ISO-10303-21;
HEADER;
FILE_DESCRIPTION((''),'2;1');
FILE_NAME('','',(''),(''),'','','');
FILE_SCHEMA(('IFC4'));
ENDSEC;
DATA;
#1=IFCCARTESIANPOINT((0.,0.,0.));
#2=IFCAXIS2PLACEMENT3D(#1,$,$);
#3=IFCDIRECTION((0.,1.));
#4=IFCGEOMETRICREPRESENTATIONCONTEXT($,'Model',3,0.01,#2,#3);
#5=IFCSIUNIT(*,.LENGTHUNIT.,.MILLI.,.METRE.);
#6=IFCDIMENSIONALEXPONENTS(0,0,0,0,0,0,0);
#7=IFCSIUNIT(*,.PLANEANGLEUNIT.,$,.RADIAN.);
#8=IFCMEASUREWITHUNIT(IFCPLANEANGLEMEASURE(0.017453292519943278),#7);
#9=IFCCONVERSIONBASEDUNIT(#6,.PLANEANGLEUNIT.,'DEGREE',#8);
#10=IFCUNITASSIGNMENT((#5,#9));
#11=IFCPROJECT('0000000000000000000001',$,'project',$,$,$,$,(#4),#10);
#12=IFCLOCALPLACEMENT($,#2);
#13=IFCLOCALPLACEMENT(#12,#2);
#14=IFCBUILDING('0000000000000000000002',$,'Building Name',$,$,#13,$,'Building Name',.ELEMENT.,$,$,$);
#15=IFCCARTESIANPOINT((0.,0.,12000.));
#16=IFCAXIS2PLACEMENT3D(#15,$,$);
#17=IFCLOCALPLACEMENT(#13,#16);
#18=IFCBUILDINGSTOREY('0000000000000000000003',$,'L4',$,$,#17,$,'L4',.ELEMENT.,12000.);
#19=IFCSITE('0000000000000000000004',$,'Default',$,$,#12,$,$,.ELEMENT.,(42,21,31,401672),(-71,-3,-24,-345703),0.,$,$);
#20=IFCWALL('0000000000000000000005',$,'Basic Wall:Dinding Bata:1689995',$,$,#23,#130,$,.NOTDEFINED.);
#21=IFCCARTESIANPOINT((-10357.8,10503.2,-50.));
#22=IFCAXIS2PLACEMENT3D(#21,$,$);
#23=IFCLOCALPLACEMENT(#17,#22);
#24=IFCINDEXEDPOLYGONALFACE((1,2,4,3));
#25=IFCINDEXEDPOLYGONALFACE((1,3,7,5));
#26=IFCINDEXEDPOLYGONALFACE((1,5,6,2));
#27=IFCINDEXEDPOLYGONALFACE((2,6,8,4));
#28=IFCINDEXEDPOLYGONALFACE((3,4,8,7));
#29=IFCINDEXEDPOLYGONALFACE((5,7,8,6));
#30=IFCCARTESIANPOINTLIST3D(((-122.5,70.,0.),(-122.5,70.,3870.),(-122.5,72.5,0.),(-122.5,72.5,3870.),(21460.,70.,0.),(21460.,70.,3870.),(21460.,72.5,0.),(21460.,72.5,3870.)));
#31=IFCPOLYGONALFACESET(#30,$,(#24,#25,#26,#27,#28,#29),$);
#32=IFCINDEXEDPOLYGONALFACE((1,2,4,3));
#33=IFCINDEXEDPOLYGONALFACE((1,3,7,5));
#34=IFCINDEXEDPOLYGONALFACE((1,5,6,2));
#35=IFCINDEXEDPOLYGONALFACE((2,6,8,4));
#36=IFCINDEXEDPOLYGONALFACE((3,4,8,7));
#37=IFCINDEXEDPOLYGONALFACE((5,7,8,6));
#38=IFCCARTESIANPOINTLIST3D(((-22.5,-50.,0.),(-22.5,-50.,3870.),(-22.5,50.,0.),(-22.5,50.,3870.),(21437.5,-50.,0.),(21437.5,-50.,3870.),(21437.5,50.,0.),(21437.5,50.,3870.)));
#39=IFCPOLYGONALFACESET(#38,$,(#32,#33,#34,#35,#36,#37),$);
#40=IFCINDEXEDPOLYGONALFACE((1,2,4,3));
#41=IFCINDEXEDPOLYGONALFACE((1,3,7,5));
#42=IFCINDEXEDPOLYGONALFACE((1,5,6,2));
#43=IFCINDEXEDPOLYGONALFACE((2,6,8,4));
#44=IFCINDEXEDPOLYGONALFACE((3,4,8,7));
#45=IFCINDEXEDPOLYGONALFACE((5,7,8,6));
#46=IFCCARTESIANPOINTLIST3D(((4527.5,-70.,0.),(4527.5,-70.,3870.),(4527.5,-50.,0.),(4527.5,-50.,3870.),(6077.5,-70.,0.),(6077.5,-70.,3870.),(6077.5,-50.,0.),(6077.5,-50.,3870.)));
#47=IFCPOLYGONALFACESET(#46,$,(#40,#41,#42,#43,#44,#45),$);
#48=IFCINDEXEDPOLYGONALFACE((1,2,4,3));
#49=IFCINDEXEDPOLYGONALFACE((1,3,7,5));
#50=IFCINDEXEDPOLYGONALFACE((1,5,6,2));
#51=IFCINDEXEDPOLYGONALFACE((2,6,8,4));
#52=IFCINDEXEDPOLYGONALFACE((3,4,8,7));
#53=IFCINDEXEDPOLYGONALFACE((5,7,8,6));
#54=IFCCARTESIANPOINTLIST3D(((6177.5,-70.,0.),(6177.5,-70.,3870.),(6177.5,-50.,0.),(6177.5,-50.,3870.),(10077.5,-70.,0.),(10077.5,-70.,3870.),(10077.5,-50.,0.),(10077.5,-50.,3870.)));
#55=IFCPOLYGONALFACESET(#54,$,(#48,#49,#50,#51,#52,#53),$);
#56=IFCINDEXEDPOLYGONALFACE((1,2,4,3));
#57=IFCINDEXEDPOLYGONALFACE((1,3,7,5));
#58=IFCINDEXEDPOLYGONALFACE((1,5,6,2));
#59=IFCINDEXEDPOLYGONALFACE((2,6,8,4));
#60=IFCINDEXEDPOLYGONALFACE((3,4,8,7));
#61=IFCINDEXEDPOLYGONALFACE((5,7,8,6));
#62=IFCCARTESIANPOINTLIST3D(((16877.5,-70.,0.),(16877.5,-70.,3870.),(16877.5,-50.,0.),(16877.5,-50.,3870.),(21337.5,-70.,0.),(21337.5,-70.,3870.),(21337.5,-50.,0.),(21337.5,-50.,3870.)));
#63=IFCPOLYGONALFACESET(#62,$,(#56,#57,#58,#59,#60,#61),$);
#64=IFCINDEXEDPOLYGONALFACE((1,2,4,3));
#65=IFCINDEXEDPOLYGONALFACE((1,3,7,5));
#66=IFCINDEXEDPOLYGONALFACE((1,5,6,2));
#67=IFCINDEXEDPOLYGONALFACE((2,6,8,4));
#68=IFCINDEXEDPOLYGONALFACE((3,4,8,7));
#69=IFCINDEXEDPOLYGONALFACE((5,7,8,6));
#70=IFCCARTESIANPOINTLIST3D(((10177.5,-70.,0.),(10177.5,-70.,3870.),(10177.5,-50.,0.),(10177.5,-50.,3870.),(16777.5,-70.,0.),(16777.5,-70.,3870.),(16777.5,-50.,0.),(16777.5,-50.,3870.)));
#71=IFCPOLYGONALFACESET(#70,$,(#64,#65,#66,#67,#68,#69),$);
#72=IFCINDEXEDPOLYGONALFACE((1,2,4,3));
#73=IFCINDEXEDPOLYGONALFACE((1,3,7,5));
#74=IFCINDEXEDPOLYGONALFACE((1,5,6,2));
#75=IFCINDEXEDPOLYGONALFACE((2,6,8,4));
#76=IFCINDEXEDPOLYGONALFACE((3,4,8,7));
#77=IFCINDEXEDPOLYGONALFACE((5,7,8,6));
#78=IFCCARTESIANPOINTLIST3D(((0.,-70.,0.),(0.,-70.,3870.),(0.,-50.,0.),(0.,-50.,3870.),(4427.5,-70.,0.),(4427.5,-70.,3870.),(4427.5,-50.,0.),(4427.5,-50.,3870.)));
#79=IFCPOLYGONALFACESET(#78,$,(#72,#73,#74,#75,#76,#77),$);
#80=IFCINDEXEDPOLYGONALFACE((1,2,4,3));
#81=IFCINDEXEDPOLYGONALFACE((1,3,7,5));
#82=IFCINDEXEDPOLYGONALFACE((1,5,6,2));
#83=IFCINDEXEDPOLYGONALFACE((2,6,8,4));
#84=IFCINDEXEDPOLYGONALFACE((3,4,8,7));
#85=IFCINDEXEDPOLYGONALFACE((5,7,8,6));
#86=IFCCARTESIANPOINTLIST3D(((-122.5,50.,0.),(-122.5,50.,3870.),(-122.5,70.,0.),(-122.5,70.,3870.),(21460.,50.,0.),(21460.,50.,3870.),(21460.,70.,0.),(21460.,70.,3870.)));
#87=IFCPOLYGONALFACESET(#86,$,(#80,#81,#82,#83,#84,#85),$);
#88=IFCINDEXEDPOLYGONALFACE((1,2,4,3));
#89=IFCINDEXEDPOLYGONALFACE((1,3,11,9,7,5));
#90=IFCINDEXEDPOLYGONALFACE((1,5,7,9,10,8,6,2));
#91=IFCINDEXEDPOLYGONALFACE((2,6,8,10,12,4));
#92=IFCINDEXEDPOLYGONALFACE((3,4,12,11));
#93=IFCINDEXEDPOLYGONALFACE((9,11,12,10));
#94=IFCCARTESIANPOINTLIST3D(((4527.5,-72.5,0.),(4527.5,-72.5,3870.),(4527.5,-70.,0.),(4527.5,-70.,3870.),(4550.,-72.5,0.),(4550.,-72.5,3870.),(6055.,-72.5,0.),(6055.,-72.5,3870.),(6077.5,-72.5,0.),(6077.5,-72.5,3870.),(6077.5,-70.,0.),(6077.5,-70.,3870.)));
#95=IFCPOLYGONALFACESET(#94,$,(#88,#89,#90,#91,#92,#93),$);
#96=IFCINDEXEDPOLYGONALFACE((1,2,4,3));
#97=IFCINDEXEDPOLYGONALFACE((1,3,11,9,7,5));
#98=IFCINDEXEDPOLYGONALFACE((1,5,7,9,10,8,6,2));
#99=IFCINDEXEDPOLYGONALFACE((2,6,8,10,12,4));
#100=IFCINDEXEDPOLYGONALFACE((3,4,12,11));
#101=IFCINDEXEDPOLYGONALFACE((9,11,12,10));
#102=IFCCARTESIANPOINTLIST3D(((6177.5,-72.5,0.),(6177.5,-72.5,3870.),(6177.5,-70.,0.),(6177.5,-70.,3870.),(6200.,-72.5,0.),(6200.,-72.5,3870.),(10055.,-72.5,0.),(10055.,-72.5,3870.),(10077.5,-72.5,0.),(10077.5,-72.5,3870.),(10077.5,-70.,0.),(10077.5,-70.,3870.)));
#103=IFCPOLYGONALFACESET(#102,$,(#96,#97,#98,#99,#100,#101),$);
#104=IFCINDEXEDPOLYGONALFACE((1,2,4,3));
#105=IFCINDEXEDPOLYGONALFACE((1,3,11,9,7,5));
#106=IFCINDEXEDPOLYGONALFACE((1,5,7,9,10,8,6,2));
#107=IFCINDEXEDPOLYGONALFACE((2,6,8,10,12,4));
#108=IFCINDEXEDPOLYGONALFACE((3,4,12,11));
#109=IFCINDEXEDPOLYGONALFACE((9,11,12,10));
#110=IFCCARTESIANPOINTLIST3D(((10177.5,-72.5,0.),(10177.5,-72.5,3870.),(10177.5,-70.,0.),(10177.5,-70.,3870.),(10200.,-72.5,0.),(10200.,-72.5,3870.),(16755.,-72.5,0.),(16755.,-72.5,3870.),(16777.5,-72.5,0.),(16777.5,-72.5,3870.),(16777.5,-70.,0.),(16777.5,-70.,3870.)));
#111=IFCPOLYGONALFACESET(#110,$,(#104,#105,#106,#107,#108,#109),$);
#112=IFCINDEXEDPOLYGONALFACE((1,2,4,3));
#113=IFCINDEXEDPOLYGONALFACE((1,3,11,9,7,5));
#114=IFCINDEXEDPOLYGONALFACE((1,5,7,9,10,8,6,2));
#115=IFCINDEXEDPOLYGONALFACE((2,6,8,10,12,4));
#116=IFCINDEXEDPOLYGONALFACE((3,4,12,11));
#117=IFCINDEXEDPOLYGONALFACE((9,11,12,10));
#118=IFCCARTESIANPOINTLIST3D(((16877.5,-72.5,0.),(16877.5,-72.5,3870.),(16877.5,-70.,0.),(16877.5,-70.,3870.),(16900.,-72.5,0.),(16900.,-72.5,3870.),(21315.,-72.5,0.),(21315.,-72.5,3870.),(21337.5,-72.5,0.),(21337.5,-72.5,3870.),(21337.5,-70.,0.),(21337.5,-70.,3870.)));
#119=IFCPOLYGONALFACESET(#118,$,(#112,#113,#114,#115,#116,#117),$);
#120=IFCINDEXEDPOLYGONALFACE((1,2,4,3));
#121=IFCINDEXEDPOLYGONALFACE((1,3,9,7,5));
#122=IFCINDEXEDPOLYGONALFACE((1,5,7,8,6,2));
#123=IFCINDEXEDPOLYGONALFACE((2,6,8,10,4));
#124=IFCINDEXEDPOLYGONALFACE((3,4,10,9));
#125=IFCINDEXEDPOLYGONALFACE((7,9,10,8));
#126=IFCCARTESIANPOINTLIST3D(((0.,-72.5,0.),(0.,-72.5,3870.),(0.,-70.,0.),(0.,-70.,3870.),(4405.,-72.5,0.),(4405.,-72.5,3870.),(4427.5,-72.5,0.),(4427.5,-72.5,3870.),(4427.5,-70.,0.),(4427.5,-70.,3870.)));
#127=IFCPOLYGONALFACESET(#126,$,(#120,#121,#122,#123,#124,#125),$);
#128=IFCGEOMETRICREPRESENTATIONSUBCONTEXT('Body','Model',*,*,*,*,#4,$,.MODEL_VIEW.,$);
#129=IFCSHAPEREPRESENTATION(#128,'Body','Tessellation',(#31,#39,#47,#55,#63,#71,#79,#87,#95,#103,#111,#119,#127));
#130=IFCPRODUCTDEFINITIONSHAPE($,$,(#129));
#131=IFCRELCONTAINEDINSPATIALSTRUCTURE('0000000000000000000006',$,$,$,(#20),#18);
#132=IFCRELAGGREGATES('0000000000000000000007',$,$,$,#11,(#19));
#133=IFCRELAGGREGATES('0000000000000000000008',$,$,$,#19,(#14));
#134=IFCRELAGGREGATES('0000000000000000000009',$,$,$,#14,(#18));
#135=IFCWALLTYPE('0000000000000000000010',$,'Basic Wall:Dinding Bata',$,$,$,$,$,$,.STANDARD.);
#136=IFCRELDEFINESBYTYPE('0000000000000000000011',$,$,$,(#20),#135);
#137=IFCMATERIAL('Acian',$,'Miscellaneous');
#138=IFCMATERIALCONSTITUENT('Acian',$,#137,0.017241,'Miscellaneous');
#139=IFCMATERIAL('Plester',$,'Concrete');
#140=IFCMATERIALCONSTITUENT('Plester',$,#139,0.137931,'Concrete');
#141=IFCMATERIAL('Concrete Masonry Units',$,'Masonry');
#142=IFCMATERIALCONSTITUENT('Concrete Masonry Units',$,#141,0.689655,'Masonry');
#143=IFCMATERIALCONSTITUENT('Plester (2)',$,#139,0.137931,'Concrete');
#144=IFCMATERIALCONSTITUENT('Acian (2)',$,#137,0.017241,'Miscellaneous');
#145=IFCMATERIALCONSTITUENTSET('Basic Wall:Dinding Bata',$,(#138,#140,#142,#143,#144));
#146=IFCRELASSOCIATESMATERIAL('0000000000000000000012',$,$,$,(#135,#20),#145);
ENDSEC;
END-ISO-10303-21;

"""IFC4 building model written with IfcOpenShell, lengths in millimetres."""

from ifc_helpers import new_model, entity, si_unit, converted_unit, direction, frame, origin, place, context, subcontext, project, spatial, indexed_curve, outline, extrude, material, constituent, constituent_set, type_object, element, save


model = new_model("IFC4")

# Units and contexts
model_context = context("Model", 3, precision=0.01, world=origin(), true_north=direction((0.0, 1.0)))
body_context = subcontext(model_context, "Body", "Model", "MODEL_VIEW")
ifc_project = project(units=[si_unit("LENGTHUNIT", "METRE", prefix="MILLI"), converted_unit("PLANEANGLEUNIT", "DEGREE", entity("IfcPlaneAngleMeasure", 0.017453292519943278), si_unit("PLANEANGLEUNIT", "RADIAN"), dimensions=[0, 0, 0, 0, 0, 0, 0])], contexts=[model_context])

# Site, building, storey
site_placement = place(None, origin())
site = spatial("IfcSite", under=ifc_project, at=site_placement, Name="Default", CompositionType="ELEMENT", RefLatitude=(42, 21, 31, 401672), RefLongitude=(-71, -3, -24, -345703), RefElevation=0.0)
building_placement = place(site_placement, origin())
building = spatial("IfcBuilding", under=site, at=building_placement, Name="Building Name", LongName="Building Name", CompositionType="ELEMENT")
storey_placement = place(building_placement, frame((0.0, 0.0, 12000.0)))
storey = spatial("IfcBuildingStorey", under=building, at=storey_placement, Name="L4", LongName="L4", CompositionType="ELEMENT", Elevation=12000.0)

# Wall
ifc_material_1 = material(Name="Acian", Category="Miscellaneous")
ifc_constituent_1 = constituent(ifc_material_1, Name="Acian", Category="Miscellaneous", fraction=0.017241)
ifc_material_2 = material(Name="Plester", Category="Concrete")
ifc_constituent_2 = constituent(ifc_material_2, Name="Plester", Category="Concrete", fraction=0.137931)
ifc_material_3 = material(Name="Concrete Masonry Units", Category="Masonry")
ifc_constituent_3 = constituent(ifc_material_3, Name="Concrete Masonry Units", Category="Masonry", fraction=0.689655)
ifc_constituent_4 = constituent(ifc_material_2, Name="Plester (2)", Category="Concrete", fraction=0.137931)
ifc_constituent_5 = constituent(ifc_material_1, Name="Acian (2)", Category="Miscellaneous", fraction=0.017241)
ifc_constituent_set = constituent_set(constituents=[ifc_constituent_1, ifc_constituent_2, ifc_constituent_3, ifc_constituent_4, ifc_constituent_5], Name="Basic Wall:Dinding Bata")
wall_type = type_object("IfcWallType", Name="Basic Wall:Dinding Bata", PredefinedType="STANDARD", material=ifc_constituent_set)
wall_1_placement = place(storey_placement, frame((-10357.8, 10503.2, -50.0)))
element("IfcWall", 1, at=wall_1_placement, inside=storey, type_object=wall_type, material=ifc_constituent_set, Name="Basic Wall:Dinding Bata:1689995", PredefinedType="NOTDEFINED", context=body_context, shape_type="SweptSolid", body=[
    extrude(outline(indexed_curve([(-1.3, -10791.2), (1.2, -10791.2), (1.3, 10791.2), (-1.2, 10791.2), (-1.3, -10791.2)], self_intersect=False)), frame((10668.8, 71.2, 0.0), z_axis=(0.0, 0.0, 1.0), x_axis=(0.0, -1.0, 0.0)), (0.0, 0.0, 1.0), 3870.0),
    extrude(outline(indexed_curve([(-10730.0, -50.0), (10730.0, -50.0), (10730.0, 50.0), (-10730.0, 50.0), (-10730.0, -50.0)], self_intersect=False)), frame((10707.5, 0.0, 0.0)), (0.0, 0.0, 1.0), 3870.0),
    extrude(outline(indexed_curve([(-775.0, -10.0), (775.0, -10.0), (775.0, 10.0), (-775.0, 10.0), (-775.0, -10.0)], self_intersect=False)), frame((5302.5, -60.0, 0.0), z_axis=(0.0, 0.0, 1.0), x_axis=(-1.0, 0.0, 0.0)), (0.0, 0.0, 1.0), 3870.0),
    extrude(outline(indexed_curve([(-1950.0, -10.0), (1950.0, -10.0), (1950.0, 10.0), (-1950.0, 10.0), (-1950.0, -10.0)], self_intersect=False)), frame((8127.5, -60.0, 0.0), z_axis=(0.0, 0.0, 1.0), x_axis=(-1.0, 0.0, 0.0)), (0.0, 0.0, 1.0), 3870.0),
    extrude(outline(indexed_curve([(-2230.0, -10.0), (2230.0, -10.0), (2230.0, 10.0), (-2230.0, 10.0), (-2230.0, -10.0)], self_intersect=False)), frame((19107.5, -60.0, 0.0), z_axis=(0.0, 0.0, 1.0), x_axis=(-1.0, 0.0, 0.0)), (0.0, 0.0, 1.0), 3870.0),
    extrude(outline(indexed_curve([(-3300.0, -10.0), (3300.0, -10.0), (3300.0, 10.0), (-3300.0, 10.0), (-3300.0, -10.0)], self_intersect=False)), frame((13477.5, -60.0, 0.0), z_axis=(0.0, 0.0, 1.0), x_axis=(-1.0, 0.0, 0.0)), (0.0, 0.0, 1.0), 3870.0),
    extrude(outline(indexed_curve([(-2213.8, -10.0), (2213.8, -10.0), (2213.8, 10.0), (-2213.8, 10.0), (-2213.8, -10.0)], self_intersect=False)), frame((2213.8, -60.0, 0.0)), (0.0, 0.0, 1.0), 3870.0),
    extrude(outline(indexed_curve([(-10791.3, -10.0), (10791.2, -10.0), (10791.3, 10.0), (-10791.2, 10.0), (-10791.3, -10.0)], self_intersect=False)), frame((10668.8, 60.0, 0.0)), (0.0, 0.0, 1.0), 3870.0),
    extrude(outline(indexed_curve([(752.5, -0.8), (775.0, -0.8), (775.0, 1.7), (-775.0, 1.7), (-775.0, -0.8), (-752.5, -0.8), (752.5, -0.8)], self_intersect=False)), frame((5302.5, -71.7, 0.0)), (0.0, 0.0, 1.0), 3870.0),
    extrude(outline(indexed_curve([(1927.5, -0.8), (1950.0, -0.8), (1950.0, 1.7), (-1950.0, 1.7), (-1950.0, -0.8), (-1927.5, -0.8), (1927.5, -0.8)], self_intersect=False)), frame((8127.5, -71.7, 0.0)), (0.0, 0.0, 1.0), 3870.0),
    extrude(outline(indexed_curve([(3277.5, -0.8), (3300.0, -0.8), (3300.0, 1.7), (-3300.0, 1.7), (-3300.0, -0.8), (-3277.5, -0.8), (3277.5, -0.8)], self_intersect=False)), frame((13477.5, -71.7, 0.0)), (0.0, 0.0, 1.0), 3870.0),
    extrude(outline(indexed_curve([(2207.5, -0.8), (2230.0, -0.8), (2230.0, 1.7), (-2230.0, 1.7), (-2230.0, -0.8), (-2207.5, -0.8), (2207.5, -0.8)], self_intersect=False)), frame((19107.5, -71.7, 0.0)), (0.0, 0.0, 1.0), 3870.0),
    extrude(outline(indexed_curve([(1753.0, -1.0), (1775.5, -1.0), (1775.5, 1.5), (-2652.0, 1.5), (-2652.0, -1.0), (1753.0, -1.0)], self_intersect=False)), frame((2652.0, -71.5, 0.0)), (0.0, 0.0, 1.0), 3870.0),
])

save(model, "model.ifc")
